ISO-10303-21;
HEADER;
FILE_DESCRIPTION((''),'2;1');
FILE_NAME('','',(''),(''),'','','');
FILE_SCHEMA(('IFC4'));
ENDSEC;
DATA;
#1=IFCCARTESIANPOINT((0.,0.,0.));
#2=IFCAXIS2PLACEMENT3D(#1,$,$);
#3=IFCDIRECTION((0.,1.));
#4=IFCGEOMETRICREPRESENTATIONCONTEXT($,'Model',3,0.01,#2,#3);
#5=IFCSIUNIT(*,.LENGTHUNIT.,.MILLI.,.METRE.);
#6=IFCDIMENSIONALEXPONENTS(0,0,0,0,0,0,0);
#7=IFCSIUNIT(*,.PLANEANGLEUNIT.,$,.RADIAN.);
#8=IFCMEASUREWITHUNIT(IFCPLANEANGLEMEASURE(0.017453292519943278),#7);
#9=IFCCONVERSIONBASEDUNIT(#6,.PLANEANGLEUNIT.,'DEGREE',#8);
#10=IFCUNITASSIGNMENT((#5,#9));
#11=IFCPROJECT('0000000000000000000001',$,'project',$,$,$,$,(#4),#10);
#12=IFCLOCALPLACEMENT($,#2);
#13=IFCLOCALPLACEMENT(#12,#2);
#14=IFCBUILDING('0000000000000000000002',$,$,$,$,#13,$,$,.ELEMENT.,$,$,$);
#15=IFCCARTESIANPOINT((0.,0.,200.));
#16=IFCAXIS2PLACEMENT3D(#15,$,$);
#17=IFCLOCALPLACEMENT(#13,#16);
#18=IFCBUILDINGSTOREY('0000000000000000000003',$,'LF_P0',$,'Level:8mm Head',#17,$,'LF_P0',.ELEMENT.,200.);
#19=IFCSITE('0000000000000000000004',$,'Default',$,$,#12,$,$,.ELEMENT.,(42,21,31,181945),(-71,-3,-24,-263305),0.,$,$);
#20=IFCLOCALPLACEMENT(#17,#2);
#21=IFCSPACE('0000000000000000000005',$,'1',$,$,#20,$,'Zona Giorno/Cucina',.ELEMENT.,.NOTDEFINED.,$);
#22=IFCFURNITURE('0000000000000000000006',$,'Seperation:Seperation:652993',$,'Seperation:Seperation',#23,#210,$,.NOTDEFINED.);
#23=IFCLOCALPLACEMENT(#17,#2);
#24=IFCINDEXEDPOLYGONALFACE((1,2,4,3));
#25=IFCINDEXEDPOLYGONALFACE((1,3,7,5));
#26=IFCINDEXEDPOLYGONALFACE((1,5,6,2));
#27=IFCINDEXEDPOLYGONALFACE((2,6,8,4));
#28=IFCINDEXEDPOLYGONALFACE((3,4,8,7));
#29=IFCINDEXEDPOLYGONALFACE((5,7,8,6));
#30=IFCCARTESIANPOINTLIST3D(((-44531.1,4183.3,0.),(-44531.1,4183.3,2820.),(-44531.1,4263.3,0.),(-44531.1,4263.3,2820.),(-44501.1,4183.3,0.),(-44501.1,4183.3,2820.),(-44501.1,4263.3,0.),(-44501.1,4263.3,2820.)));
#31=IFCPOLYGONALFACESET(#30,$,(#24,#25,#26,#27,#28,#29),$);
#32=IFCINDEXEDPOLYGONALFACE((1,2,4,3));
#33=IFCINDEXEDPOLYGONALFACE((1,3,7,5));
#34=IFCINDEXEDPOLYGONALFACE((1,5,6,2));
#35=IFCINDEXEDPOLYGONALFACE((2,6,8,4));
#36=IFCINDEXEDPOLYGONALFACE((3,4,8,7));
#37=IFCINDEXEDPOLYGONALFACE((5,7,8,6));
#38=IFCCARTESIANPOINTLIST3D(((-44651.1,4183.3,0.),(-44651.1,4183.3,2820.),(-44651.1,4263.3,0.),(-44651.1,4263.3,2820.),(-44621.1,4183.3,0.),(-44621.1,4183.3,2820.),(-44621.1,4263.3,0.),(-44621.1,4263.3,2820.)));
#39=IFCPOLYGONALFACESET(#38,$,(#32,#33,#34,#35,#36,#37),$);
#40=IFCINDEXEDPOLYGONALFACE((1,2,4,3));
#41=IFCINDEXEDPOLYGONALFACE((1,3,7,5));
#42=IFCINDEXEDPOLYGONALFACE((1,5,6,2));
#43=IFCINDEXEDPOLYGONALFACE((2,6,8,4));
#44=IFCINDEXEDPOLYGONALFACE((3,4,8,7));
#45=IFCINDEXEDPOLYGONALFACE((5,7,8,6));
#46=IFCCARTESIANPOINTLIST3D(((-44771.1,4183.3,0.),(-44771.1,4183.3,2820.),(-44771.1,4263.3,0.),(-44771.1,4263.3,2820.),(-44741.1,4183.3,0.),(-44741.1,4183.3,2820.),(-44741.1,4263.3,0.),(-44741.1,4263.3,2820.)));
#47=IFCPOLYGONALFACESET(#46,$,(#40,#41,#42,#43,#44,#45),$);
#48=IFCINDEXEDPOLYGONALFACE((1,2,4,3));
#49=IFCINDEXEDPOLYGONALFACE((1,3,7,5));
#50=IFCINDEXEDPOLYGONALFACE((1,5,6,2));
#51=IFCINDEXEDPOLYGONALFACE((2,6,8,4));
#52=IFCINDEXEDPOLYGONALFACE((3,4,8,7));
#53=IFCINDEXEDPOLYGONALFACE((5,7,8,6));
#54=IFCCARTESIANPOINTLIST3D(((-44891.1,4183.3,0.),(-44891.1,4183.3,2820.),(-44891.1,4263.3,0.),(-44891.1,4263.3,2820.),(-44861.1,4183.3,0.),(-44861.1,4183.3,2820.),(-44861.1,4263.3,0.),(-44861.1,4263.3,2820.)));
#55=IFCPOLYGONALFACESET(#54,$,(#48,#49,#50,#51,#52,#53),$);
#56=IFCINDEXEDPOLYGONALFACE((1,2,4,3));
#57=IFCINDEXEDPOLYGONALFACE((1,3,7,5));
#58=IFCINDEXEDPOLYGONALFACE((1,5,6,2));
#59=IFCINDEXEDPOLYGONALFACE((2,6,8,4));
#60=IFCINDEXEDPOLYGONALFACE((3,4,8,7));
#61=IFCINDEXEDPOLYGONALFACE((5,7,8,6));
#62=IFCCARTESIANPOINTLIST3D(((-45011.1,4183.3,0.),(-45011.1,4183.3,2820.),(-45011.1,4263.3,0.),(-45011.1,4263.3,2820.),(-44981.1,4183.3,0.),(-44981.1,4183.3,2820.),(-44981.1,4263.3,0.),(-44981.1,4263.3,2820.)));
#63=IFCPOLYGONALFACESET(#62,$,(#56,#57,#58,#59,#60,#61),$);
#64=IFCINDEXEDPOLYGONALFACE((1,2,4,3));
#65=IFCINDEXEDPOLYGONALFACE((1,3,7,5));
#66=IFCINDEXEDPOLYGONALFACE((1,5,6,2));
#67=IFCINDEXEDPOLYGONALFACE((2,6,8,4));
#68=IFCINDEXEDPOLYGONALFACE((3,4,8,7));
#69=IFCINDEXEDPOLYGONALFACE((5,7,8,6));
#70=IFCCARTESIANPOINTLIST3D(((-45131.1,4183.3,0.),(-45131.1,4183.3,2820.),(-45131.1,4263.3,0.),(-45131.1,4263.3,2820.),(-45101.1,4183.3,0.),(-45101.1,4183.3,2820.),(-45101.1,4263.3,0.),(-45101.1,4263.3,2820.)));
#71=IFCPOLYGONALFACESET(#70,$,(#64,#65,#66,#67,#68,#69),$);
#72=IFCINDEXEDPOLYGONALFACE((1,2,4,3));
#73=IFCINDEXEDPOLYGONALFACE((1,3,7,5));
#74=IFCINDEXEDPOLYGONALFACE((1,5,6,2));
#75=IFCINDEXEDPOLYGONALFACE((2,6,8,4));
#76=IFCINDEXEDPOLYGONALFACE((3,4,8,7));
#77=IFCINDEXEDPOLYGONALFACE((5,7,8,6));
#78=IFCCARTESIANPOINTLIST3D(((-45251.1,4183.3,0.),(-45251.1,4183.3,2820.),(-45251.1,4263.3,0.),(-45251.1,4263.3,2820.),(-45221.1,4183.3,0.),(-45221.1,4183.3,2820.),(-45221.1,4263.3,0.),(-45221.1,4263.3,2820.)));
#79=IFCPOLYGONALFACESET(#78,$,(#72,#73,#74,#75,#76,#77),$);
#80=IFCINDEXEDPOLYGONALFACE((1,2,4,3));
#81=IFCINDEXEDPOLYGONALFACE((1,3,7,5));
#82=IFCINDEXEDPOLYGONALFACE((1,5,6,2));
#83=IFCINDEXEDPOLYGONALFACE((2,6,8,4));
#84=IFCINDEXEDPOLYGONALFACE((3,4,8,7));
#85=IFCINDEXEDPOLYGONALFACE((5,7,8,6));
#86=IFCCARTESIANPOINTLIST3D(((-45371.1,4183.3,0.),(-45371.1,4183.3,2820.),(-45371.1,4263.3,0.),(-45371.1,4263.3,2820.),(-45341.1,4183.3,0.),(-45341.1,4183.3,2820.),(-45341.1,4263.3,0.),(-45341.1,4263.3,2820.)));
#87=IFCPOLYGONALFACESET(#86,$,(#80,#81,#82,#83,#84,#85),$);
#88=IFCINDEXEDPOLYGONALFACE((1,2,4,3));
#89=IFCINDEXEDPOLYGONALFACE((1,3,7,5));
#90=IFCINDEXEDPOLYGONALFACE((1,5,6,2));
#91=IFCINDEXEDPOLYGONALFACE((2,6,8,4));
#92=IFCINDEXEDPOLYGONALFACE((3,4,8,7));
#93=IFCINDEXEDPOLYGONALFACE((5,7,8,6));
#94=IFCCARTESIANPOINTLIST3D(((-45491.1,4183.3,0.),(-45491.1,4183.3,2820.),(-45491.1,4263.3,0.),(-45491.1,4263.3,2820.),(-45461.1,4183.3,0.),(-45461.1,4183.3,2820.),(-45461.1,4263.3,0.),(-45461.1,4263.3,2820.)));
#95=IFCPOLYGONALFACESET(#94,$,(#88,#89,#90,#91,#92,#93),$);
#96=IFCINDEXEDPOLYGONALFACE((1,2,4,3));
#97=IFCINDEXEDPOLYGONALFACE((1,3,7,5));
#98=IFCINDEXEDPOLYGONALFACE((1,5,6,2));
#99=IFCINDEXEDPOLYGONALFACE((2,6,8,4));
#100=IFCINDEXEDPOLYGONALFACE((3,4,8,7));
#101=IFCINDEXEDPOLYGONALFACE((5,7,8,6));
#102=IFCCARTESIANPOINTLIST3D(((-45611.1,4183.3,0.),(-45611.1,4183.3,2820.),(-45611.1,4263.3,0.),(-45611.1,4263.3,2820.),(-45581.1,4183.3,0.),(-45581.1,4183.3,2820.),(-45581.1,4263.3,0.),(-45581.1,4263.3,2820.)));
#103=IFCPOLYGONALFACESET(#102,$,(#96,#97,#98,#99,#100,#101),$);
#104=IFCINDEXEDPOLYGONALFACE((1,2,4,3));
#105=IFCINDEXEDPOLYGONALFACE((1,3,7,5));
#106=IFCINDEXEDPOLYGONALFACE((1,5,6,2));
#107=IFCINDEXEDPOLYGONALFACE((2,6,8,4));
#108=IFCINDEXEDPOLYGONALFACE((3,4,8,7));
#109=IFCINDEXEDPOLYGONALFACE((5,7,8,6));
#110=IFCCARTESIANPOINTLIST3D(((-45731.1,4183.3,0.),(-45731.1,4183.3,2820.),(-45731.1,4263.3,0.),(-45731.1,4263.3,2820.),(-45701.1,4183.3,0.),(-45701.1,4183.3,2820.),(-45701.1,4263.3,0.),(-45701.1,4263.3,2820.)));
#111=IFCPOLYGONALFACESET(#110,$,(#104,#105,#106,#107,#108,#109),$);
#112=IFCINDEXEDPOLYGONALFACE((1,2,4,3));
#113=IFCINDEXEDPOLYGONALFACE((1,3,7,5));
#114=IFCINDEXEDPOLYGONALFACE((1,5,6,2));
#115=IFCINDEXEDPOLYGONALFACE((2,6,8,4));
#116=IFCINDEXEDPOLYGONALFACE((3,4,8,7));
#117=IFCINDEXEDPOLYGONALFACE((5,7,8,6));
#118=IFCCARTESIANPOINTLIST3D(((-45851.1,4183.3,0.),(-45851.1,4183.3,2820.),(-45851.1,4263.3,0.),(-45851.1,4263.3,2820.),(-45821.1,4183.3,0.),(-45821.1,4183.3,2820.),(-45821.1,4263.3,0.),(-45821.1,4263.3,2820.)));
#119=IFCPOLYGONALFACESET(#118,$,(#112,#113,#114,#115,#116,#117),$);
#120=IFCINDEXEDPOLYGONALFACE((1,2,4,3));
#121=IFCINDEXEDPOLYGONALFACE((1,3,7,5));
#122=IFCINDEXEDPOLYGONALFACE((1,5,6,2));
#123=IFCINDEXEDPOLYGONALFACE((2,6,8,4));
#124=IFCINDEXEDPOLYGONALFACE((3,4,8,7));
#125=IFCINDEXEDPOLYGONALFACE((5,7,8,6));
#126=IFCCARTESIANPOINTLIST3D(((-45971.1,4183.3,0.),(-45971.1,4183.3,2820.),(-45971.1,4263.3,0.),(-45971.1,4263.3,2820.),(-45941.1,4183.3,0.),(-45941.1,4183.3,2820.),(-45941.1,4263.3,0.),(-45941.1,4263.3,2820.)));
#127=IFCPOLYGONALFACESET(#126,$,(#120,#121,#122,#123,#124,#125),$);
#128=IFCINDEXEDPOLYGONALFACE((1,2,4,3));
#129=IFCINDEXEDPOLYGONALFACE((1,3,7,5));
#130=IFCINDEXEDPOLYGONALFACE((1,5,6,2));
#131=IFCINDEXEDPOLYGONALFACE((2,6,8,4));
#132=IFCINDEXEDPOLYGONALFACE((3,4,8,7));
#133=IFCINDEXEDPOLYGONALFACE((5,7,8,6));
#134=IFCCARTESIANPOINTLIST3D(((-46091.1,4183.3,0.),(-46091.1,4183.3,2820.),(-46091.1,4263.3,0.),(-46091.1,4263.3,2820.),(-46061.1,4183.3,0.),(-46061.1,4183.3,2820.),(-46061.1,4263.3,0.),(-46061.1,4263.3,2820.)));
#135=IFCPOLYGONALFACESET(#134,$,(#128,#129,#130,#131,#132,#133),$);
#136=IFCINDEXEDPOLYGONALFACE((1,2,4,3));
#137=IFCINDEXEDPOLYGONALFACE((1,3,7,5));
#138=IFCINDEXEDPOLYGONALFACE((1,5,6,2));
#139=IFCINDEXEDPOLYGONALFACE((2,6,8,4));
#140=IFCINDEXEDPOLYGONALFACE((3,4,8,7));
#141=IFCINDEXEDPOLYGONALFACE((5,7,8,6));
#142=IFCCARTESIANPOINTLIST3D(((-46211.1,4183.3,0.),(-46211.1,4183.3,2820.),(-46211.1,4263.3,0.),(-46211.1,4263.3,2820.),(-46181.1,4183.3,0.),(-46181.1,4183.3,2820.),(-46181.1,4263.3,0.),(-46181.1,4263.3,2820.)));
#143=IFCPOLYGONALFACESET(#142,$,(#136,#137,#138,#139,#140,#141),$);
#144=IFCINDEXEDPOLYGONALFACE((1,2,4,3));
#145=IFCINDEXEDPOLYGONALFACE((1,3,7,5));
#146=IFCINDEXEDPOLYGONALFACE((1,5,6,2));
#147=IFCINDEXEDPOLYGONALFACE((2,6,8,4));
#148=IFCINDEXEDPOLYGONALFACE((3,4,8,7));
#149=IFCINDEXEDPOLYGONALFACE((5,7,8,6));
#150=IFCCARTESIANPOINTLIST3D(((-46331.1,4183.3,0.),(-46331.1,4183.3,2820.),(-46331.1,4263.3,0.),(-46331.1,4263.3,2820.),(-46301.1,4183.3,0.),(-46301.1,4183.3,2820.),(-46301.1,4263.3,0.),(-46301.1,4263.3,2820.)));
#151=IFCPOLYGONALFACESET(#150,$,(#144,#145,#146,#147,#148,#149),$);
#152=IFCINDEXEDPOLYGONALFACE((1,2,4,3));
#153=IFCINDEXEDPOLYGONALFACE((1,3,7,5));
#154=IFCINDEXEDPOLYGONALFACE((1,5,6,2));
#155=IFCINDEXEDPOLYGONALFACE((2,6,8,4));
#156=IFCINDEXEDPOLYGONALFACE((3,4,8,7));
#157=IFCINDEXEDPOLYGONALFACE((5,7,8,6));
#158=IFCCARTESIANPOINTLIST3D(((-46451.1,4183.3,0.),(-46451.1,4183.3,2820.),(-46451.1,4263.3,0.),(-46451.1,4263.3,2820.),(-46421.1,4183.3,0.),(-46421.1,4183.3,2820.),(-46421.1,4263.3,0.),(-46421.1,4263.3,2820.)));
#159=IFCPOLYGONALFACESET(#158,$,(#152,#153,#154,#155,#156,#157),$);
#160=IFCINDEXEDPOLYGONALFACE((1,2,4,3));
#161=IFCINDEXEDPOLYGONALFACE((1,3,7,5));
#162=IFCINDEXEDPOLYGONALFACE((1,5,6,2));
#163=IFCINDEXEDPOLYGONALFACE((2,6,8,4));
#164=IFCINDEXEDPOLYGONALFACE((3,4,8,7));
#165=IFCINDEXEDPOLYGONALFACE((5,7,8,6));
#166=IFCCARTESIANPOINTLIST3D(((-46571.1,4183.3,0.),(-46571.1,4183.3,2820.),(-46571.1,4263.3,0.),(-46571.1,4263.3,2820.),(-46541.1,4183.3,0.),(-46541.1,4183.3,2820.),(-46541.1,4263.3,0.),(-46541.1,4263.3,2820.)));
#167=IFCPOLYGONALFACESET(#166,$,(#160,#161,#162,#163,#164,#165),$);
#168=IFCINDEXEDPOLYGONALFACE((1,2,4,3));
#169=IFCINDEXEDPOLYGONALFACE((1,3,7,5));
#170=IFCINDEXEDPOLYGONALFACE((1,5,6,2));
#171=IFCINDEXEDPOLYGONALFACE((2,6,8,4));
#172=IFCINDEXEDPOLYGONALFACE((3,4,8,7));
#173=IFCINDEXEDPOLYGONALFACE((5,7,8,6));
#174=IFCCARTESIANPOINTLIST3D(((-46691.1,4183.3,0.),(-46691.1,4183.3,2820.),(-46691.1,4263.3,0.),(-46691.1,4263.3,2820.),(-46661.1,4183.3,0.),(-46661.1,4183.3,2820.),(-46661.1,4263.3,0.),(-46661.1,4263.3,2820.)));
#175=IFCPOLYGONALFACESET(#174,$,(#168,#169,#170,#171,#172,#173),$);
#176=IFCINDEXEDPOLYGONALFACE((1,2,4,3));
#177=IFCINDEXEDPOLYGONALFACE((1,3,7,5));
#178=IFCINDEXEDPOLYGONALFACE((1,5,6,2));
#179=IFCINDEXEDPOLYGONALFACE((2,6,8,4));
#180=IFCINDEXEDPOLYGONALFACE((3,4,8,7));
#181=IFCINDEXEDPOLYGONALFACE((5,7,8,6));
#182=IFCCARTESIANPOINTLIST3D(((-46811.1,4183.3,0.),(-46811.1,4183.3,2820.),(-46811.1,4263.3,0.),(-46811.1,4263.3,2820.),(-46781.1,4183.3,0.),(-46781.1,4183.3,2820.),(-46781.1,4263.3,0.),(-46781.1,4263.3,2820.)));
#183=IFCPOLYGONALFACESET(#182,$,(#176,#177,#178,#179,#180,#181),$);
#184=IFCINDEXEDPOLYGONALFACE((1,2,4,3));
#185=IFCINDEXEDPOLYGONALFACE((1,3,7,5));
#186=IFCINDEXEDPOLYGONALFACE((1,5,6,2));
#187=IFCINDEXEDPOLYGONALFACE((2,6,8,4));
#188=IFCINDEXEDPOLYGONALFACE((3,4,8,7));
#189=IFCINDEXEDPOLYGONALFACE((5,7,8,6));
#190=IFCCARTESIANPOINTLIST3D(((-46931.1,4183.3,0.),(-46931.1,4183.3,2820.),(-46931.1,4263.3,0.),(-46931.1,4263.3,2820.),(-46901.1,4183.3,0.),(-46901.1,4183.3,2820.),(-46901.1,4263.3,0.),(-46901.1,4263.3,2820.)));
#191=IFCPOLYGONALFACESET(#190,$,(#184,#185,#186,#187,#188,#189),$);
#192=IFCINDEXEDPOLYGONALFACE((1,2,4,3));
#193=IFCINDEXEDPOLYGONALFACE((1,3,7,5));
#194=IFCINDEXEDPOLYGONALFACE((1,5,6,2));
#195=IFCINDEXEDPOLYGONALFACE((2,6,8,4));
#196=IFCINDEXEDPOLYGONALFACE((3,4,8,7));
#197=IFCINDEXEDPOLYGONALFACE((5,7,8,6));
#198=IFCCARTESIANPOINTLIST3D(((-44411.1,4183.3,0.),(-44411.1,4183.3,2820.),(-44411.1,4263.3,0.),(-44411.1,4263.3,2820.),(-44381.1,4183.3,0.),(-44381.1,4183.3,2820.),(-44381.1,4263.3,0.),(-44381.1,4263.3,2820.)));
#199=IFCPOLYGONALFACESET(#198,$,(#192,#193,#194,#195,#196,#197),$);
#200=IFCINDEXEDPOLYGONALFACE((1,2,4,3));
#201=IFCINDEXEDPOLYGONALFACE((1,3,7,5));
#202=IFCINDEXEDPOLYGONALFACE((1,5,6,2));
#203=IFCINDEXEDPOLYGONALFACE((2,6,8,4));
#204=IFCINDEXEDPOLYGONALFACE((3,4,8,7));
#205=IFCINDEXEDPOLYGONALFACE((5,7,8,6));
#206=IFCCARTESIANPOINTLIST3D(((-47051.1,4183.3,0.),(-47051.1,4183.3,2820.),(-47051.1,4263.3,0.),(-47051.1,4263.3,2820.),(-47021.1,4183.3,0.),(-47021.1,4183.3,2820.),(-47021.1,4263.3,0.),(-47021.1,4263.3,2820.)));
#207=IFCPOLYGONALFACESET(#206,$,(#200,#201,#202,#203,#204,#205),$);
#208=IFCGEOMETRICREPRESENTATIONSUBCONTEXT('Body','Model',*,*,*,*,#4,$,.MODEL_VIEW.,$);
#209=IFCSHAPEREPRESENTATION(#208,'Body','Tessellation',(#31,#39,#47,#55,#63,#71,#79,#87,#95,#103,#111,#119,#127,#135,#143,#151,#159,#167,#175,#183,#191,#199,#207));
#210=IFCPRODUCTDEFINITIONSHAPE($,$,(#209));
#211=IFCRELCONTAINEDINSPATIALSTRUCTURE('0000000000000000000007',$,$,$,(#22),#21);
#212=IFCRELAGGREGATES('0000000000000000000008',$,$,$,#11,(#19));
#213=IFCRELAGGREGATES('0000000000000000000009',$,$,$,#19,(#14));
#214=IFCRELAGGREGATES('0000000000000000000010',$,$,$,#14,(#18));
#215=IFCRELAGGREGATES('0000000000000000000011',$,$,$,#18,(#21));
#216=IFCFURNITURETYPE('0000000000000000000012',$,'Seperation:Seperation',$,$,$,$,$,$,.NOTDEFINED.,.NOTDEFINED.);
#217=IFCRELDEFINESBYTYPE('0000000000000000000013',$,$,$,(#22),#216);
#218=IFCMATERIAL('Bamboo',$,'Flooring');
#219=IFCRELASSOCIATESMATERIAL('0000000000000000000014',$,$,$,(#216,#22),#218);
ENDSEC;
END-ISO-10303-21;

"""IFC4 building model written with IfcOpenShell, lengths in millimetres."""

from ifc_helpers import new_model, entity, si_unit, converted_unit, direction, frame, origin, place, context, subcontext, project, spatial, indexed_curve, outline, extrude, source, transform, mapped, material, type_object, type_shapes, element, save


model = new_model("IFC4")

# Units and contexts
model_context = context("Model", 3, precision=0.01, world=origin(), true_north=direction((0.0, 1.0)))
body_context = subcontext(model_context, "Body", "Model", "MODEL_VIEW")
ifc_project = project(units=[si_unit("LENGTHUNIT", "METRE", prefix="MILLI"), converted_unit("PLANEANGLEUNIT", "DEGREE", entity("IfcPlaneAngleMeasure", 0.017453292519943278), si_unit("PLANEANGLEUNIT", "RADIAN"), dimensions=[0, 0, 0, 0, 0, 0, 0])], contexts=[model_context])

# Site, building, storey
site_placement = place(None, origin())
site = spatial("IfcSite", under=ifc_project, at=site_placement, Name="Default", CompositionType="ELEMENT", RefLatitude=(42, 21, 31, 181945), RefLongitude=(-71, -3, -24, -263305), RefElevation=0.0)
building_placement = place(site_placement, origin())
building = spatial("IfcBuilding", under=site, at=building_placement, CompositionType="ELEMENT")
storey_placement = place(building_placement, frame((0.0, 0.0, 200.0)))
storey = spatial("IfcBuildingStorey", under=building, at=storey_placement, Name="LF_P0", ObjectType="Level:8mm Head", LongName="LF_P0", CompositionType="ELEMENT", Elevation=200.0)

# Shared definitions
space_placement = place(storey_placement, origin())
space = spatial("IfcSpace", under=storey, at=space_placement, Name="1", LongName="Zona Giorno/Cucina", CompositionType="ELEMENT", PredefinedType="NOTDEFINED")

# Furniture
ifc_material_1 = material(Name="Bamboo", Category="Flooring")
furniture_type_1 = type_object("IfcFurnitureType", Name="Seperation:Seperation", AssemblyPlace="NOTDEFINED", PredefinedType="NOTDEFINED", material=ifc_material_1)
shared_shape_1 = source(origin(), body_context, "Body", "SweptSolid", [
    extrude(outline(indexed_curve([(-40.0, -15.0), (40.0, -15.0), (40.0, 15.0), (-40.0, 15.0), (-40.0, -15.0)], self_intersect=False)), frame((-44516.1, 4223.3, 200.0), z_axis=(0.0, 0.0, 1.0), x_axis=(0.0, -1.0, 0.0)), (0.0, 0.0, 1.0), 2820.0),
    extrude(outline(indexed_curve([(-40.0, -15.0), (40.0, -15.0), (40.0, 15.0), (-40.0, 15.0), (-40.0, -15.0)], self_intersect=False)), frame((-44636.1, 4223.3, 200.0), z_axis=(0.0, 0.0, 1.0), x_axis=(0.0, -1.0, 0.0)), (0.0, 0.0, 1.0), 2820.0),
    extrude(outline(indexed_curve([(-40.0, -15.0), (40.0, -15.0), (40.0, 15.0), (-40.0, 15.0), (-40.0, -15.0)], self_intersect=False)), frame((-44756.1, 4223.3, 200.0), z_axis=(0.0, 0.0, 1.0), x_axis=(0.0, -1.0, 0.0)), (0.0, 0.0, 1.0), 2820.0),
    extrude(outline(indexed_curve([(-40.0, -15.0), (40.0, -15.0), (40.0, 15.0), (-40.0, 15.0), (-40.0, -15.0)], self_intersect=False)), frame((-44876.1, 4223.3, 200.0), z_axis=(0.0, 0.0, 1.0), x_axis=(0.0, -1.0, 0.0)), (0.0, 0.0, 1.0), 2820.0),
    extrude(outline(indexed_curve([(-40.0, -15.0), (40.0, -15.0), (40.0, 15.0), (-40.0, 15.0), (-40.0, -15.0)], self_intersect=False)), frame((-44996.1, 4223.3, 200.0), z_axis=(0.0, 0.0, 1.0), x_axis=(0.0, -1.0, 0.0)), (0.0, 0.0, 1.0), 2820.0),
    extrude(outline(indexed_curve([(-40.0, -15.0), (40.0, -15.0), (40.0, 15.0), (-40.0, 15.0), (-40.0, -15.0)], self_intersect=False)), frame((-45116.1, 4223.3, 200.0), z_axis=(0.0, 0.0, 1.0), x_axis=(0.0, -1.0, 0.0)), (0.0, 0.0, 1.0), 2820.0),
    extrude(outline(indexed_curve([(-40.0, -15.0), (40.0, -15.0), (40.0, 15.0), (-40.0, 15.0), (-40.0, -15.0)], self_intersect=False)), frame((-45236.1, 4223.3, 200.0), z_axis=(0.0, 0.0, 1.0), x_axis=(0.0, -1.0, 0.0)), (0.0, 0.0, 1.0), 2820.0),
    extrude(outline(indexed_curve([(-40.0, -15.0), (40.0, -15.0), (40.0, 15.0), (-40.0, 15.0), (-40.0, -15.0)], self_intersect=False)), frame((-45356.1, 4223.3, 200.0), z_axis=(0.0, 0.0, 1.0), x_axis=(0.0, -1.0, 0.0)), (0.0, 0.0, 1.0), 2820.0),
    extrude(outline(indexed_curve([(-40.0, -15.0), (40.0, -15.0), (40.0, 15.0), (-40.0, 15.0), (-40.0, -15.0)], self_intersect=False)), frame((-45476.1, 4223.3, 200.0), z_axis=(0.0, 0.0, 1.0), x_axis=(0.0, -1.0, 0.0)), (0.0, 0.0, 1.0), 2820.0),
    extrude(outline(indexed_curve([(-40.0, -15.0), (40.0, -15.0), (40.0, 15.0), (-40.0, 15.0), (-40.0, -15.0)], self_intersect=False)), frame((-45596.1, 4223.3, 200.0), z_axis=(0.0, 0.0, 1.0), x_axis=(0.0, -1.0, 0.0)), (0.0, 0.0, 1.0), 2820.0),
    extrude(outline(indexed_curve([(-40.0, -15.0), (40.0, -15.0), (40.0, 15.0), (-40.0, 15.0), (-40.0, -15.0)], self_intersect=False)), frame((-45716.1, 4223.3, 200.0), z_axis=(0.0, 0.0, 1.0), x_axis=(0.0, -1.0, 0.0)), (0.0, 0.0, 1.0), 2820.0),
    extrude(outline(indexed_curve([(-40.0, -15.0), (40.0, -15.0), (40.0, 15.0), (-40.0, 15.0), (-40.0, -15.0)], self_intersect=False)), frame((-45836.1, 4223.3, 200.0), z_axis=(0.0, 0.0, 1.0), x_axis=(0.0, -1.0, 0.0)), (0.0, 0.0, 1.0), 2820.0),
    extrude(outline(indexed_curve([(-40.0, -15.0), (40.0, -15.0), (40.0, 15.0), (-40.0, 15.0), (-40.0, -15.0)], self_intersect=False)), frame((-45956.1, 4223.3, 200.0), z_axis=(0.0, 0.0, 1.0), x_axis=(0.0, -1.0, 0.0)), (0.0, 0.0, 1.0), 2820.0),
    extrude(outline(indexed_curve([(-40.0, -15.0), (40.0, -15.0), (40.0, 15.0), (-40.0, 15.0), (-40.0, -15.0)], self_intersect=False)), frame((-46076.1, 4223.3, 200.0), z_axis=(0.0, 0.0, 1.0), x_axis=(0.0, -1.0, 0.0)), (0.0, 0.0, 1.0), 2820.0),
    extrude(outline(indexed_curve([(-40.0, -15.0), (40.0, -15.0), (40.0, 15.0), (-40.0, 15.0), (-40.0, -15.0)], self_intersect=False)), frame((-46196.1, 4223.3, 200.0), z_axis=(0.0, 0.0, 1.0), x_axis=(0.0, -1.0, 0.0)), (0.0, 0.0, 1.0), 2820.0),
    extrude(outline(indexed_curve([(-40.0, -15.0), (40.0, -15.0), (40.0, 15.0), (-40.0, 15.0), (-40.0, -15.0)], self_intersect=False)), frame((-46316.1, 4223.3, 200.0), z_axis=(0.0, 0.0, 1.0), x_axis=(0.0, -1.0, 0.0)), (0.0, 0.0, 1.0), 2820.0),
    extrude(outline(indexed_curve([(-40.0, -15.0), (40.0, -15.0), (40.0, 15.0), (-40.0, 15.0), (-40.0, -15.0)], self_intersect=False)), frame((-46436.1, 4223.3, 200.0), z_axis=(0.0, 0.0, 1.0), x_axis=(0.0, -1.0, 0.0)), (0.0, 0.0, 1.0), 2820.0),
    extrude(outline(indexed_curve([(-40.0, -15.0), (40.0, -15.0), (40.0, 15.0), (-40.0, 15.0), (-40.0, -15.0)], self_intersect=False)), frame((-46556.1, 4223.3, 200.0), z_axis=(0.0, 0.0, 1.0), x_axis=(0.0, -1.0, 0.0)), (0.0, 0.0, 1.0), 2820.0),
    extrude(outline(indexed_curve([(-40.0, -15.0), (40.0, -15.0), (40.0, 15.0), (-40.0, 15.0), (-40.0, -15.0)], self_intersect=False)), frame((-46676.1, 4223.3, 200.0), z_axis=(0.0, 0.0, 1.0), x_axis=(0.0, -1.0, 0.0)), (0.0, 0.0, 1.0), 2820.0),
    extrude(outline(indexed_curve([(-40.0, -15.0), (40.0, -15.0), (40.0, 15.0), (-40.0, 15.0), (-40.0, -15.0)], self_intersect=False)), frame((-46796.1, 4223.3, 200.0), z_axis=(0.0, 0.0, 1.0), x_axis=(0.0, -1.0, 0.0)), (0.0, 0.0, 1.0), 2820.0),
    extrude(outline(indexed_curve([(-40.0, -15.0), (40.0, -15.0), (40.0, 15.0), (-40.0, 15.0), (-40.0, -15.0)], self_intersect=False)), frame((-46916.1, 4223.3, 200.0), z_axis=(0.0, 0.0, 1.0), x_axis=(0.0, -1.0, 0.0)), (0.0, 0.0, 1.0), 2820.0),
    extrude(outline(indexed_curve([(-40.0, -15.0), (40.0, -15.0), (40.0, 15.0), (-40.0, 15.0), (-40.0, -15.0)], self_intersect=False)), frame((-44396.1, 4223.3, 200.0), z_axis=(0.0, 0.0, 1.0), x_axis=(0.0, -1.0, 0.0)), (0.0, 0.0, 1.0), 2820.0),
    extrude(outline(indexed_curve([(-40.0, -15.0), (40.0, -15.0), (40.0, 15.0), (-40.0, 15.0), (-40.0, -15.0)], self_intersect=False)), frame((-47036.1, 4223.3, 200.0), z_axis=(0.0, 0.0, 1.0), x_axis=(0.0, -1.0, 0.0)), (0.0, 0.0, 1.0), 2820.0),
])
type_shapes(furniture_type_1, [shared_shape_1])
furniture_1_placement = place(space_placement, frame((0.0, 0.0, -200.0)))
element("IfcFurniture", 1, at=furniture_1_placement, inside=space, type_object=furniture_type_1, material=ifc_material_1, Name="Seperation:Seperation:652993", ObjectType="Seperation:Seperation", PredefinedType="NOTDEFINED", context=body_context, shape_type="MappedRepresentation", body=[
    mapped(shared_shape_1, transform((0.0, 0.0, 0.0), scale=1.0)),
])

save(model, "model.ifc")
